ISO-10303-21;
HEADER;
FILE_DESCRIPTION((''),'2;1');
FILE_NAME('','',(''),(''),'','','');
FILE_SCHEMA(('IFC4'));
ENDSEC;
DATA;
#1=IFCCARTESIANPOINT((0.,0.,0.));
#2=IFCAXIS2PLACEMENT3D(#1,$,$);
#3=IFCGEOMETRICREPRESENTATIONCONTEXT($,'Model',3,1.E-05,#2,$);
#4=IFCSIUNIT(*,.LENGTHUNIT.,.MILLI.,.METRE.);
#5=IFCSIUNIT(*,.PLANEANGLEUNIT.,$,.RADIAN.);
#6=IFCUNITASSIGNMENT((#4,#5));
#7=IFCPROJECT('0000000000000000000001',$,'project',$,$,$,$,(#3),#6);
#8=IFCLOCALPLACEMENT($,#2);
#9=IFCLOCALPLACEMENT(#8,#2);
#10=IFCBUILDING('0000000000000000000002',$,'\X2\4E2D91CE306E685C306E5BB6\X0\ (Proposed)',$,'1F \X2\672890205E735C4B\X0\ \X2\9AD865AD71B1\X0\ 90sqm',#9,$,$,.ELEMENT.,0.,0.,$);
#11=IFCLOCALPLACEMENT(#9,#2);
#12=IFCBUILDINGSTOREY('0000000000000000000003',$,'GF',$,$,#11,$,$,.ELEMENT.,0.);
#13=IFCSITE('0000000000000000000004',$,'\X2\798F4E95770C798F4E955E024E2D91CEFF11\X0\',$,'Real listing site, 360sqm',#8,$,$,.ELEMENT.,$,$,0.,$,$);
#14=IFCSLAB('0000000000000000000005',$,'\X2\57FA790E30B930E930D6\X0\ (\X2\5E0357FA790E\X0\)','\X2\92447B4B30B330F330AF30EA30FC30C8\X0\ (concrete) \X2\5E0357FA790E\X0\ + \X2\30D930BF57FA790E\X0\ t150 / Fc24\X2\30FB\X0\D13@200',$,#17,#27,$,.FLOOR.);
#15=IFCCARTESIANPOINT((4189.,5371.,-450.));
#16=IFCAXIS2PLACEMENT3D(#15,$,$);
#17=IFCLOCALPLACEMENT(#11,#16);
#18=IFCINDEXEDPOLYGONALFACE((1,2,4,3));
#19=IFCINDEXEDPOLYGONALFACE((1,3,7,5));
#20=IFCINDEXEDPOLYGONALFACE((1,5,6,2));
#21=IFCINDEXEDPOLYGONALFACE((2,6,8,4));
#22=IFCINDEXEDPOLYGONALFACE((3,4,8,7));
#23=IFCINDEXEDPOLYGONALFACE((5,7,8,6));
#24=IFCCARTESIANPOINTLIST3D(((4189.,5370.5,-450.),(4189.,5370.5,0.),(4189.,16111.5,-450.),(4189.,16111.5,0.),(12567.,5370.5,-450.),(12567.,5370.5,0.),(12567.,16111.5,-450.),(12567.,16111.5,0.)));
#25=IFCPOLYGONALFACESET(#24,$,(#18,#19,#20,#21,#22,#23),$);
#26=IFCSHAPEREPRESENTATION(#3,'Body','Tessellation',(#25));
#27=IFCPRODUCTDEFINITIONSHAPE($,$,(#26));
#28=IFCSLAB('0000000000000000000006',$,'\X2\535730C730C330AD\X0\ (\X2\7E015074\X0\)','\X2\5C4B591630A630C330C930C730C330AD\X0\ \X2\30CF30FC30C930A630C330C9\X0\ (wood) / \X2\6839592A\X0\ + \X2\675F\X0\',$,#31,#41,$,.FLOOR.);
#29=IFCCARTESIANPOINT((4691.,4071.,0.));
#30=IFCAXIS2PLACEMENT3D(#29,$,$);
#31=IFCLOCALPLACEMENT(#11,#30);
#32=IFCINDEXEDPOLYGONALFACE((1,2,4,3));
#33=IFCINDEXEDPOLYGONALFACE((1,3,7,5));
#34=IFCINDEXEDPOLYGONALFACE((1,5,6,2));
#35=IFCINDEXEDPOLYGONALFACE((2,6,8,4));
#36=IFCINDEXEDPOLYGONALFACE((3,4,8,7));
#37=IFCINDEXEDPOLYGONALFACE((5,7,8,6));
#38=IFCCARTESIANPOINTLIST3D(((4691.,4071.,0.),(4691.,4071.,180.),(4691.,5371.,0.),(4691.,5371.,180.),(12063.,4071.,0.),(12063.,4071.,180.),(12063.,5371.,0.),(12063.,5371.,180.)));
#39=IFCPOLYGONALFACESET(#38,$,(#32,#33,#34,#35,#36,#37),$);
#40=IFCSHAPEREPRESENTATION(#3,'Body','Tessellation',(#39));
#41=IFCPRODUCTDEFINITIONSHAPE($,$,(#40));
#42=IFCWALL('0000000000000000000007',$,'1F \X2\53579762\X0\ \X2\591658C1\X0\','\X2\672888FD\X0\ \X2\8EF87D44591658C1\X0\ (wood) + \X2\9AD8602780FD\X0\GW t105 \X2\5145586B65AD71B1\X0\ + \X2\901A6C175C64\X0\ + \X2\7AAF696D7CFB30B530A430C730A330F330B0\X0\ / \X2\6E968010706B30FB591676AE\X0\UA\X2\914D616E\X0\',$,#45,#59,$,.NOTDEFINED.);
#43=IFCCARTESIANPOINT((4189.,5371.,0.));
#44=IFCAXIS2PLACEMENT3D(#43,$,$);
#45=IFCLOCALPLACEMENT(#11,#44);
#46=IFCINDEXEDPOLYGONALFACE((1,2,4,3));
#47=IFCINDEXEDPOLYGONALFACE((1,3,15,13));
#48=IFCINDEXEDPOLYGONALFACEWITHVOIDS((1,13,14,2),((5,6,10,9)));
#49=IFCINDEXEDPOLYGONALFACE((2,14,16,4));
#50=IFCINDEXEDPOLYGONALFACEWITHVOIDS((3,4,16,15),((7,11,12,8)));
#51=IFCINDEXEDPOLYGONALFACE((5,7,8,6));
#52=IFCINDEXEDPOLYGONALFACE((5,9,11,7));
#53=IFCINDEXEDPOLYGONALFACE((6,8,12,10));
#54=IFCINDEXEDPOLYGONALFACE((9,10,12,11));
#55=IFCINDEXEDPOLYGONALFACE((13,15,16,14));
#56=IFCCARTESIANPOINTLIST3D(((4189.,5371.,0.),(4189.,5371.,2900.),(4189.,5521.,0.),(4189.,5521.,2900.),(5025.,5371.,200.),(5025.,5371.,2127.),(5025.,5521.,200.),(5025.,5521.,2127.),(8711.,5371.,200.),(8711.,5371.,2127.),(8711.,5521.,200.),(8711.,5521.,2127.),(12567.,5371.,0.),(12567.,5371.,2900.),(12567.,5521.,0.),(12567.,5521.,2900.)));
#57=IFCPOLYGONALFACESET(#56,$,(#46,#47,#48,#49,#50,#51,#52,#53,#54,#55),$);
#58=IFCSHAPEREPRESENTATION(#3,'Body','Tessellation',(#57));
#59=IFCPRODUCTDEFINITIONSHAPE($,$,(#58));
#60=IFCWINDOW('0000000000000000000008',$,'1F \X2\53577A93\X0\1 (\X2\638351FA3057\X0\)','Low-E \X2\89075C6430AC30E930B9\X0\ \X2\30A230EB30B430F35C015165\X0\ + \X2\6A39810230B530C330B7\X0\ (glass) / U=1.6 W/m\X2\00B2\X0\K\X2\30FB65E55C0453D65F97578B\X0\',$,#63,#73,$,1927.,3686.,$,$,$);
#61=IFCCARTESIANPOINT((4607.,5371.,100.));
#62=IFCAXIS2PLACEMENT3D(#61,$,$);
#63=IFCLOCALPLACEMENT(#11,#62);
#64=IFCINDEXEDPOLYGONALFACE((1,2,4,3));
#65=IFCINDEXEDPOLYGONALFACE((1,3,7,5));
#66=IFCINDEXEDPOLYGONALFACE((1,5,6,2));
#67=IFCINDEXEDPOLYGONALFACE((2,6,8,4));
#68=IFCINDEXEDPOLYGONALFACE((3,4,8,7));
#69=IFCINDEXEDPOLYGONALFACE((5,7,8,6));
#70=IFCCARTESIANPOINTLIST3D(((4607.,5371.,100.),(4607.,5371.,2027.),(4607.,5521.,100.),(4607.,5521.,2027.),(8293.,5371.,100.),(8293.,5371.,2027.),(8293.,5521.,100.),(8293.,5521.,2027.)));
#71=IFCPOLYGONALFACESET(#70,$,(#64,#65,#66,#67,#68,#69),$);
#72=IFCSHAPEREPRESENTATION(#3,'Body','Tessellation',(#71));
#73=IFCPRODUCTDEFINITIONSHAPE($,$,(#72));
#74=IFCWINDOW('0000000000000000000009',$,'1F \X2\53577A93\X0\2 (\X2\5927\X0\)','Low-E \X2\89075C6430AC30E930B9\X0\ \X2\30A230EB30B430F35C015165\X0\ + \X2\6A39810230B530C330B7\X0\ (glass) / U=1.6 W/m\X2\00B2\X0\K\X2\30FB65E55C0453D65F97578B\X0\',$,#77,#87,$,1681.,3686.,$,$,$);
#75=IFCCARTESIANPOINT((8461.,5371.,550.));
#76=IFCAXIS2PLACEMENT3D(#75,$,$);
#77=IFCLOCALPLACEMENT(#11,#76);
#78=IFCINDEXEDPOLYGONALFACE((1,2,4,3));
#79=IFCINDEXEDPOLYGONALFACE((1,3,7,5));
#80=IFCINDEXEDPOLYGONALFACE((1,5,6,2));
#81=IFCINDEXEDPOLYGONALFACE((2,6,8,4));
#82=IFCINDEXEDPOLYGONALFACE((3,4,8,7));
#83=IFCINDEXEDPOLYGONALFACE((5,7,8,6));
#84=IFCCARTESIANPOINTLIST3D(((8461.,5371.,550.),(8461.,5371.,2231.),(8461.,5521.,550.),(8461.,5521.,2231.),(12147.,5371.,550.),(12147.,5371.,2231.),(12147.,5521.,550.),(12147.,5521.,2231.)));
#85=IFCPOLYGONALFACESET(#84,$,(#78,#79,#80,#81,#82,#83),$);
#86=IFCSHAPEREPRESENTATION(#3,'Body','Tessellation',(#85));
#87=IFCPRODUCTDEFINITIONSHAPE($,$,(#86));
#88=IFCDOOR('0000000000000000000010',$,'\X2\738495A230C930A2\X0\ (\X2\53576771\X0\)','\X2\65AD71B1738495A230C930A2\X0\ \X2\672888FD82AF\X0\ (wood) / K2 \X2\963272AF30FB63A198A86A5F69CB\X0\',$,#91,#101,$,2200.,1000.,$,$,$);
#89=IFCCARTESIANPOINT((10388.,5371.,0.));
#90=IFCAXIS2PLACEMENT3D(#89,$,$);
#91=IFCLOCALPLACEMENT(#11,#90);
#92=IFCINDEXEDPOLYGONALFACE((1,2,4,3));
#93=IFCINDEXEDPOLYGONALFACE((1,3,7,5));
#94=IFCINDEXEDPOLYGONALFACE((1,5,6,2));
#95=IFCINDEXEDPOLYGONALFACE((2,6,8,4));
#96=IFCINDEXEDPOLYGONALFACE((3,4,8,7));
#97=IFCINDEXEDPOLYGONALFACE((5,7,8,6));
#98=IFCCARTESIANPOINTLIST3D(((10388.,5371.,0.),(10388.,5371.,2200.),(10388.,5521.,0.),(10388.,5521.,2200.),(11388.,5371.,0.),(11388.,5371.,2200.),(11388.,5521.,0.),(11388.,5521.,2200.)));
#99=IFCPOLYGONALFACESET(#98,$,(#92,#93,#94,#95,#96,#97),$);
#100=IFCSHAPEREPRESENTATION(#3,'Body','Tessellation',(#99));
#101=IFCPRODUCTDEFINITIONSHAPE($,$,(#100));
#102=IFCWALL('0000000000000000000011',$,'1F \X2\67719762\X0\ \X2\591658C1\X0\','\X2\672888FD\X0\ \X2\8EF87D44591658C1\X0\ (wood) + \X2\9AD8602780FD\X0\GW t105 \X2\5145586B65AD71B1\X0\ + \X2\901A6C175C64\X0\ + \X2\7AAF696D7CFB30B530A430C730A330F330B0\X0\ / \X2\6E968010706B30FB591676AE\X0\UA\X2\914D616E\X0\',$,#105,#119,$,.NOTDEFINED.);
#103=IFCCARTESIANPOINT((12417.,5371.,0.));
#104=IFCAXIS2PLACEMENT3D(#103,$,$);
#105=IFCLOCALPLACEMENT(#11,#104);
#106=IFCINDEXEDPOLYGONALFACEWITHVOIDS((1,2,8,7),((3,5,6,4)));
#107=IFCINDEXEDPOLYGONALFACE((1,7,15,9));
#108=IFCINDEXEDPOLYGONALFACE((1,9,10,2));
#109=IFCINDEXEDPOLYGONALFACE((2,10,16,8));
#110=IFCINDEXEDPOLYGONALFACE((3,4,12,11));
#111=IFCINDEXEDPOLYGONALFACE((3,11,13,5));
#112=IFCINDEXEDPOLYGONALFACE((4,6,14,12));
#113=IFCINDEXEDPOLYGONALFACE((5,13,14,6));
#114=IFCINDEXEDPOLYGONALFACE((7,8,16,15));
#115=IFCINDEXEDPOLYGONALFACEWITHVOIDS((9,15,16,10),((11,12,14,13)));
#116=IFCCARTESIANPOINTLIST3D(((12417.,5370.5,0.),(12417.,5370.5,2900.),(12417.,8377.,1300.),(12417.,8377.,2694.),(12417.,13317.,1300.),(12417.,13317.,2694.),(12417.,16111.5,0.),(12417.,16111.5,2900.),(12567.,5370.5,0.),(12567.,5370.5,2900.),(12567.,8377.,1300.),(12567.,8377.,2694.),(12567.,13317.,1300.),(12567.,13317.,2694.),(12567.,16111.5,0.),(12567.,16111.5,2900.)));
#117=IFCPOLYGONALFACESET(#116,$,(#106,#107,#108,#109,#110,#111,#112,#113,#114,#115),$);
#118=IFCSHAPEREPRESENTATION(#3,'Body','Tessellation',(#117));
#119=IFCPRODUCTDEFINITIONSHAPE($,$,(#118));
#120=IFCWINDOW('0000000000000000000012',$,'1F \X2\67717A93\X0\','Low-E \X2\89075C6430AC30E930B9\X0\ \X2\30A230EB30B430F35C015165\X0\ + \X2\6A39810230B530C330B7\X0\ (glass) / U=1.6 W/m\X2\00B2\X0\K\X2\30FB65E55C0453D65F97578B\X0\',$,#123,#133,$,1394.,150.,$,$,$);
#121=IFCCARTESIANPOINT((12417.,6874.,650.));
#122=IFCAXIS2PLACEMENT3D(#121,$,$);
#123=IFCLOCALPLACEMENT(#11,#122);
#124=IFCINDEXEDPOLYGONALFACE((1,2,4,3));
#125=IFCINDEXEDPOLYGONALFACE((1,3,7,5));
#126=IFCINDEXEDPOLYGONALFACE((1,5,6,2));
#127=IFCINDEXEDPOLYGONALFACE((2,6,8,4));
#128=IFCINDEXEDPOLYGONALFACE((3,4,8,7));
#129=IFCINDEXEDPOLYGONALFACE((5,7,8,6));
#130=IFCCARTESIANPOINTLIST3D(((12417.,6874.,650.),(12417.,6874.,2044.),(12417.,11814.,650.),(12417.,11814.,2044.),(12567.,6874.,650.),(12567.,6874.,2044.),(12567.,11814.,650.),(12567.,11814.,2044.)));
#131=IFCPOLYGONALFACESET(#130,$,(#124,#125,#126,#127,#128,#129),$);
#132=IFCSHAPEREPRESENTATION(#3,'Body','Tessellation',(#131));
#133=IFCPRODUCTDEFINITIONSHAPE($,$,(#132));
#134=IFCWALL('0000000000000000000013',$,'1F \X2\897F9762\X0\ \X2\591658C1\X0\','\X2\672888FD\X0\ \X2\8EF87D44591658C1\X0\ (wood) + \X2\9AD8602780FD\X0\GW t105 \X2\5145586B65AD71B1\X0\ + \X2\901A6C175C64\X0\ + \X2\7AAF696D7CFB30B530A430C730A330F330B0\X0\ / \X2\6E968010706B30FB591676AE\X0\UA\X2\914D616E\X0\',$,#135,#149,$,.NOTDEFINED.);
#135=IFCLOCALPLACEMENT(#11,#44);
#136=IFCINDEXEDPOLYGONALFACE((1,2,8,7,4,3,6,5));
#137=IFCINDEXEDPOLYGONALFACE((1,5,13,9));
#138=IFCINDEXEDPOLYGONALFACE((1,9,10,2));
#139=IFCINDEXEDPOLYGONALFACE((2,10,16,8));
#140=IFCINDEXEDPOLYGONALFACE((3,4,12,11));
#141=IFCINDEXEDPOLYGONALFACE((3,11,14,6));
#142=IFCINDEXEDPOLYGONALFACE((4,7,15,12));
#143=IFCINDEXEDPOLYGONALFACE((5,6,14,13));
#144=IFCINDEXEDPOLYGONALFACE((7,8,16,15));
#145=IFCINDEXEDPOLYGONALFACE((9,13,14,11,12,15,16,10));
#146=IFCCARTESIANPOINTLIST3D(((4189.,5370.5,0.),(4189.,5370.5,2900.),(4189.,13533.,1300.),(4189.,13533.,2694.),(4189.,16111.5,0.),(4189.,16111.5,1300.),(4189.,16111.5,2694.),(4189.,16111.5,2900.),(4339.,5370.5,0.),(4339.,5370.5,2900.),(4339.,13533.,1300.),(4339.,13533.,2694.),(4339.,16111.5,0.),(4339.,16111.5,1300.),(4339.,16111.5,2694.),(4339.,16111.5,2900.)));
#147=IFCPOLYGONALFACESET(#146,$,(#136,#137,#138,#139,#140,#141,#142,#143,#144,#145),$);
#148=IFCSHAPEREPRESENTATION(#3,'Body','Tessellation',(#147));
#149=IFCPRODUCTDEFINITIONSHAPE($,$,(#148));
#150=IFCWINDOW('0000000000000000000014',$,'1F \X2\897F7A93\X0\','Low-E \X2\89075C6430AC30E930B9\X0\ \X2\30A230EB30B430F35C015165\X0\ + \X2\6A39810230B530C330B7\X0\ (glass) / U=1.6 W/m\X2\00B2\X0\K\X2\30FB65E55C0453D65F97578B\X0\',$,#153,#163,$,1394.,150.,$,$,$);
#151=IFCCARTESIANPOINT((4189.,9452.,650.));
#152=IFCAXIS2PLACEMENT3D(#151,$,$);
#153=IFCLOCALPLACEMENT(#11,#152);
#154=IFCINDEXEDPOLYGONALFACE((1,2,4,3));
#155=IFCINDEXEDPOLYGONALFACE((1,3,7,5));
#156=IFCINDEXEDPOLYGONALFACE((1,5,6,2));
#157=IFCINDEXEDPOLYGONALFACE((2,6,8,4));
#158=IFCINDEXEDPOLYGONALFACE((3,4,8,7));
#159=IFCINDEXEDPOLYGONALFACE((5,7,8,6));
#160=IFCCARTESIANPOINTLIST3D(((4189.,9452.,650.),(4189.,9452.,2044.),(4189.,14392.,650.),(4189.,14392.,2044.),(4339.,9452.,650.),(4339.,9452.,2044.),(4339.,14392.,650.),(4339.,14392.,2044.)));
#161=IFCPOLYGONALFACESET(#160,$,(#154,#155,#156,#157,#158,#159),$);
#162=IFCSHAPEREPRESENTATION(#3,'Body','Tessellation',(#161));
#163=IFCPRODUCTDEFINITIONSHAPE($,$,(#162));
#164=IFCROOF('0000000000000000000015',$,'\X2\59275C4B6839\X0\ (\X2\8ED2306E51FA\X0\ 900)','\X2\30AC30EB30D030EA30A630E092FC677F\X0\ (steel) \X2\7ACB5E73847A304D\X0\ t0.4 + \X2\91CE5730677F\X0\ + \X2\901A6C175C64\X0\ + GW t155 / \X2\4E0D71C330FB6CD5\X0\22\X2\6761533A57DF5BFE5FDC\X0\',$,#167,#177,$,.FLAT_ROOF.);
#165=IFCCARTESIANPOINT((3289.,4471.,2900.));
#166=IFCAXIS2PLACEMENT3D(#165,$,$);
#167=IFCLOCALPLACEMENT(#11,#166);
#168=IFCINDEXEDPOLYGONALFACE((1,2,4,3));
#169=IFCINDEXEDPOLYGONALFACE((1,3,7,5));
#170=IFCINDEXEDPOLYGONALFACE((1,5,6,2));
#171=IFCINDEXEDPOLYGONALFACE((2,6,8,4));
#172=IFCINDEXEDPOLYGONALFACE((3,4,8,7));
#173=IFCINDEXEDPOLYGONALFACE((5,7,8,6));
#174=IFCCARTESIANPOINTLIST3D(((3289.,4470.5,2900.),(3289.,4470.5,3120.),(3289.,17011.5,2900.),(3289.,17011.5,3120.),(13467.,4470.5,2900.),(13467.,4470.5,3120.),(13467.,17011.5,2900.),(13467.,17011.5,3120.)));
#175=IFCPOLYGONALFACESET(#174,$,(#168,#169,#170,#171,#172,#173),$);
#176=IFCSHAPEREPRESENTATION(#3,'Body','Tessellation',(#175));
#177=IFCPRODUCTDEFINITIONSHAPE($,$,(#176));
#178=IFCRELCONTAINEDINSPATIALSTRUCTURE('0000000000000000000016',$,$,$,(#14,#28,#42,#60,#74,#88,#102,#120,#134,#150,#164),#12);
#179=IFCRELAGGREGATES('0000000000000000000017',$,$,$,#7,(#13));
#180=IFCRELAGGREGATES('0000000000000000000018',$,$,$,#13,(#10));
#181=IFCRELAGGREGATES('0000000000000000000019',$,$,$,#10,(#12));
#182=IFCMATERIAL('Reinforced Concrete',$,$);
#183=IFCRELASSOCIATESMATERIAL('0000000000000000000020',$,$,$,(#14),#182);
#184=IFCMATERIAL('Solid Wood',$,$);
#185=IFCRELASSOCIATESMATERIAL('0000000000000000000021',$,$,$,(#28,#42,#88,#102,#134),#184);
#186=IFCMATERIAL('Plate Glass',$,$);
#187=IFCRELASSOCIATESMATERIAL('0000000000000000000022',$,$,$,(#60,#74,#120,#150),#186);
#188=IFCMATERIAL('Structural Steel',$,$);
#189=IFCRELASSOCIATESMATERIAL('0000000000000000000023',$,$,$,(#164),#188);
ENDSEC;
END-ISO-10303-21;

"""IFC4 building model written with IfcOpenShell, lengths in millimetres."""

from ifc_helpers import new_model, si_unit, frame, frame_2d, origin, place, context, project, spatial, rectangle, extrude, material, element, fill, save


model = new_model("IFC4")

# Units and contexts
model_context = context("Model", 3, precision=1e-05, world=origin())
ifc_project = project(units=[si_unit("LENGTHUNIT", "METRE", prefix="MILLI"), si_unit("PLANEANGLEUNIT", "RADIAN")], contexts=[model_context])

# Site, building, storey
site_placement = place(None, origin())
site = spatial("IfcSite", under=ifc_project, at=site_placement, Name="福井県福井市中野１", ObjectType="Real listing site, 360sqm", CompositionType="ELEMENT", RefElevation=0.0)
building_placement = place(site_placement, origin())
building = spatial("IfcBuilding", under=site, at=building_placement, Name="中野の桜の家 (Proposed)", ObjectType="1F 木造平屋 高断熱 90sqm", CompositionType="ELEMENT", ElevationOfRefHeight=0.0, ElevationOfTerrain=0.0)
storey_placement = place(building_placement, origin())
storey = spatial("IfcBuildingStorey", under=building, at=storey_placement, Name="GF", CompositionType="ELEMENT", Elevation=0.0)

# Slabs
ifc_material_1 = material(Name="Reinforced Concrete")
slab_1_placement = place(storey_placement, frame((4189.0, 5371.0, -450.0)))
element("IfcSlab", 1, at=slab_1_placement, inside=storey, material=ifc_material_1, Name="基礎スラブ (布基礎)", Description="鉄筋コンクリート (concrete) 布基礎 + ベタ基礎 t150 / Fc24・D13@200", PredefinedType="FLOOR", context=model_context, shape_type="SweptSolid", body=[
    extrude(rectangle(XDim=8378.0, YDim=10741.0, at=frame_2d((4189.0, 5370.0))), frame((4189.0, 5371.0, -450.0)), (0.0, 0.0, 1.0), 450.0),
])
ifc_material_2 = material(Name="Solid Wood")
slab_2_placement = place(storey_placement, frame((4691.0, 4071.0, 0.0)))
element("IfcSlab", 2, at=slab_2_placement, inside=storey, material=ifc_material_2, Name="南デッキ (縁側)", Description="屋外ウッドデッキ ハードウッド (wood) / 根太 + 束", PredefinedType="FLOOR", context=model_context, shape_type="SweptSolid", body=[
    extrude(rectangle(XDim=7372.0, YDim=1300.0, at=frame_2d((3686.0, 650.0))), frame((4691.0, 4071.0, 0.0)), (0.0, 0.0, 1.0), 180.0),
])

# Wall, openings, windows, door
wall_1_placement = place(storey_placement, frame((4189.0, 5371.0, 0.0)))
wall_1 = element("IfcWall", 3, at=wall_1_placement, inside=storey, material=ifc_material_2, Name="1F 南面 外壁", Description="木製 軸組外壁 (wood) + 高性能GW t105 充填断熱 + 通気層 + 窯業系サイディング / 準耐火・外皮UA配慮", PredefinedType="NOTDEFINED", context=model_context, shape_type="SweptSolid", body=[
    extrude(rectangle(XDim=8378.0, YDim=150.0, at=frame_2d((4189.0, 75.0))), frame((4189.0, 5371.0, 0.0)), (0.0, 0.0, 1.0), 2900.0),
])
opening_1_placement = place(storey_placement, frame((4607.0, 5371.0, 100.0)))
opening_1 = element("IfcOpeningElement", 4, at=opening_1_placement, cuts=wall_1, PredefinedType="NOTDEFINED", context=model_context, shape_type="SweptSolid", body=[
    extrude(rectangle(XDim=3686.0, YDim=150.0, at=frame_2d((1843.0, 75.0))), frame((4607.0, 5371.0, 100.0)), (0.0, 0.0, 1.0), 1927.0),
])
opening_2_placement = place(storey_placement, frame((8461.0, 5371.0, 550.0)))
opening_2 = element("IfcOpeningElement", 5, at=opening_2_placement, cuts=wall_1, PredefinedType="NOTDEFINED", context=model_context, shape_type="SweptSolid", body=[
    extrude(rectangle(XDim=3686.0, YDim=150.0, at=frame_2d((1843.0, 75.0))), frame((8461.0, 5371.0, 550.0)), (0.0, 0.0, 1.0), 1681.0),
])
opening_3_placement = place(storey_placement, frame((10388.0, 5371.0, 0.0)))
opening_3 = element("IfcOpeningElement", 6, at=opening_3_placement, cuts=wall_1, PredefinedType="NOTDEFINED", context=model_context, shape_type="SweptSolid", body=[
    extrude(rectangle(XDim=1000.0, YDim=150.0, at=frame_2d((500.0, 75.0))), frame((10388.0, 5371.0, 0.0)), (0.0, 0.0, 1.0), 2200.0),
])
ifc_material_3 = material(Name="Plate Glass")
window_1_placement = place(storey_placement, frame((4607.0, 5371.0, 100.0)))
window_1 = element("IfcWindow", 7, at=window_1_placement, inside=storey, material=ifc_material_3, Name="1F 南窓1 (掃出し)", Description="Low-E 複層ガラス アルゴン封入 + 樹脂サッシ (glass) / U=1.6 W/m²K・日射取得型", OverallHeight=1927.0, OverallWidth=3686.0, context=model_context, shape_type="SweptSolid", body=[
    extrude(rectangle(XDim=3686.0, YDim=150.0, at=frame_2d((1843.0, 75.0))), frame((4607.0, 5371.0, 100.0)), (0.0, 0.0, 1.0), 1927.0),
])
fill(opening_1, window_1)
window_2_placement = place(storey_placement, frame((8461.0, 5371.0, 550.0)))
window_2 = element("IfcWindow", 8, at=window_2_placement, inside=storey, material=ifc_material_3, Name="1F 南窓2 (大)", Description="Low-E 複層ガラス アルゴン封入 + 樹脂サッシ (glass) / U=1.6 W/m²K・日射取得型", OverallHeight=1681.0, OverallWidth=3686.0, context=model_context, shape_type="SweptSolid", body=[
    extrude(rectangle(XDim=3686.0, YDim=150.0, at=frame_2d((1843.0, 75.0))), frame((8461.0, 5371.0, 550.0)), (0.0, 0.0, 1.0), 1681.0),
])
fill(opening_2, window_2)
door_placement = place(storey_placement, frame((10388.0, 5371.0, 0.0)))
door = element("IfcDoor", 9, at=door_placement, inside=storey, material=ifc_material_2, Name="玄関ドア (南東)", Description="断熱玄関ドア 木製芯 (wood) / K2 防犯・採風機構", OverallHeight=2200.0, OverallWidth=1000.0, context=model_context, shape_type="SweptSolid", body=[
    extrude(rectangle(XDim=1000.0, YDim=150.0, at=frame_2d((500.0, 75.0))), frame((10388.0, 5371.0, 0.0)), (0.0, 0.0, 1.0), 2200.0),
])
fill(opening_3, door)

# Walls, openings, windows
wall_2_placement = place(storey_placement, frame((12417.0, 5371.0, 0.0)))
wall_2 = element("IfcWall", 10, at=wall_2_placement, inside=storey, material=ifc_material_2, Name="1F 東面 外壁", Description="木製 軸組外壁 (wood) + 高性能GW t105 充填断熱 + 通気層 + 窯業系サイディング / 準耐火・外皮UA配慮", PredefinedType="NOTDEFINED", context=model_context, shape_type="SweptSolid", body=[
    extrude(rectangle(XDim=150.0, YDim=10741.0, at=frame_2d((75.0, 5370.0))), frame((12417.0, 5371.0, 0.0)), (0.0, 0.0, 1.0), 2900.0),
])
opening_4_placement = place(storey_placement, frame((12417.0, 6874.0, 650.0)))
opening_4 = element("IfcOpeningElement", 11, at=opening_4_placement, cuts=wall_2, PredefinedType="NOTDEFINED", context=model_context, shape_type="SweptSolid", body=[
    extrude(rectangle(XDim=150.0, YDim=4940.0, at=frame_2d((75.0, 2470.0))), frame((12417.0, 6874.0, 650.0)), (0.0, 0.0, 1.0), 1394.0),
])
window_3_placement = place(storey_placement, frame((12417.0, 6874.0, 650.0)))
window_3 = element("IfcWindow", 12, at=window_3_placement, inside=storey, material=ifc_material_3, Name="1F 東窓", Description="Low-E 複層ガラス アルゴン封入 + 樹脂サッシ (glass) / U=1.6 W/m²K・日射取得型", OverallHeight=1394.0, OverallWidth=150.0, context=model_context, shape_type="SweptSolid", body=[
    extrude(rectangle(XDim=150.0, YDim=4940.0, at=frame_2d((75.0, 2470.0))), frame((12417.0, 6874.0, 650.0)), (0.0, 0.0, 1.0), 1394.0),
])
fill(opening_4, window_3)
wall_3_placement = place(storey_placement, frame((4189.0, 5371.0, 0.0)))
wall_3 = element("IfcWall", 13, at=wall_3_placement, inside=storey, material=ifc_material_2, Name="1F 西面 外壁", Description="木製 軸組外壁 (wood) + 高性能GW t105 充填断熱 + 通気層 + 窯業系サイディング / 準耐火・外皮UA配慮", PredefinedType="NOTDEFINED", context=model_context, shape_type="SweptSolid", body=[
    extrude(rectangle(XDim=150.0, YDim=10741.0, at=frame_2d((75.0, 5370.0))), frame((4189.0, 5371.0, 0.0)), (0.0, 0.0, 1.0), 2900.0),
])
opening_5_placement = place(storey_placement, frame((4189.0, 9452.0, 650.0)))
opening_5 = element("IfcOpeningElement", 14, at=opening_5_placement, cuts=wall_3, PredefinedType="NOTDEFINED", context=model_context, shape_type="SweptSolid", body=[
    extrude(rectangle(XDim=150.0, YDim=4940.0, at=frame_2d((75.0, 2470.0))), frame((4189.0, 9452.0, 650.0)), (0.0, 0.0, 1.0), 1394.0),
])
window_4_placement = place(storey_placement, frame((4189.0, 9452.0, 650.0)))
window_4 = element("IfcWindow", 15, at=window_4_placement, inside=storey, material=ifc_material_3, Name="1F 西窓", Description="Low-E 複層ガラス アルゴン封入 + 樹脂サッシ (glass) / U=1.6 W/m²K・日射取得型", OverallHeight=1394.0, OverallWidth=150.0, context=model_context, shape_type="SweptSolid", body=[
    extrude(rectangle(XDim=150.0, YDim=4940.0, at=frame_2d((75.0, 2470.0))), frame((4189.0, 9452.0, 650.0)), (0.0, 0.0, 1.0), 1394.0),
])
fill(opening_5, window_4)

# Roof
ifc_material_4 = material(Name="Structural Steel")
roof_placement = place(storey_placement, frame((3289.0, 4471.0, 2900.0)))
element("IfcRoof", 16, at=roof_placement, inside=storey, material=ifc_material_4, Name="大屋根 (軒の出 900)", Description="ガルバリウム鋼板 (steel) 立平葺き t0.4 + 野地板 + 通気層 + GW t155 / 不燃・法22条区域対応", PredefinedType="FLAT_ROOF", context=model_context, shape_type="SweptSolid", body=[
    extrude(rectangle(XDim=10178.0, YDim=12541.0, at=frame_2d((5089.0, 6270.0))), frame((3289.0, 4471.0, 2900.0)), (0.0, 0.0, 1.0), 220.0),
])

save(model, "model.ifc")
